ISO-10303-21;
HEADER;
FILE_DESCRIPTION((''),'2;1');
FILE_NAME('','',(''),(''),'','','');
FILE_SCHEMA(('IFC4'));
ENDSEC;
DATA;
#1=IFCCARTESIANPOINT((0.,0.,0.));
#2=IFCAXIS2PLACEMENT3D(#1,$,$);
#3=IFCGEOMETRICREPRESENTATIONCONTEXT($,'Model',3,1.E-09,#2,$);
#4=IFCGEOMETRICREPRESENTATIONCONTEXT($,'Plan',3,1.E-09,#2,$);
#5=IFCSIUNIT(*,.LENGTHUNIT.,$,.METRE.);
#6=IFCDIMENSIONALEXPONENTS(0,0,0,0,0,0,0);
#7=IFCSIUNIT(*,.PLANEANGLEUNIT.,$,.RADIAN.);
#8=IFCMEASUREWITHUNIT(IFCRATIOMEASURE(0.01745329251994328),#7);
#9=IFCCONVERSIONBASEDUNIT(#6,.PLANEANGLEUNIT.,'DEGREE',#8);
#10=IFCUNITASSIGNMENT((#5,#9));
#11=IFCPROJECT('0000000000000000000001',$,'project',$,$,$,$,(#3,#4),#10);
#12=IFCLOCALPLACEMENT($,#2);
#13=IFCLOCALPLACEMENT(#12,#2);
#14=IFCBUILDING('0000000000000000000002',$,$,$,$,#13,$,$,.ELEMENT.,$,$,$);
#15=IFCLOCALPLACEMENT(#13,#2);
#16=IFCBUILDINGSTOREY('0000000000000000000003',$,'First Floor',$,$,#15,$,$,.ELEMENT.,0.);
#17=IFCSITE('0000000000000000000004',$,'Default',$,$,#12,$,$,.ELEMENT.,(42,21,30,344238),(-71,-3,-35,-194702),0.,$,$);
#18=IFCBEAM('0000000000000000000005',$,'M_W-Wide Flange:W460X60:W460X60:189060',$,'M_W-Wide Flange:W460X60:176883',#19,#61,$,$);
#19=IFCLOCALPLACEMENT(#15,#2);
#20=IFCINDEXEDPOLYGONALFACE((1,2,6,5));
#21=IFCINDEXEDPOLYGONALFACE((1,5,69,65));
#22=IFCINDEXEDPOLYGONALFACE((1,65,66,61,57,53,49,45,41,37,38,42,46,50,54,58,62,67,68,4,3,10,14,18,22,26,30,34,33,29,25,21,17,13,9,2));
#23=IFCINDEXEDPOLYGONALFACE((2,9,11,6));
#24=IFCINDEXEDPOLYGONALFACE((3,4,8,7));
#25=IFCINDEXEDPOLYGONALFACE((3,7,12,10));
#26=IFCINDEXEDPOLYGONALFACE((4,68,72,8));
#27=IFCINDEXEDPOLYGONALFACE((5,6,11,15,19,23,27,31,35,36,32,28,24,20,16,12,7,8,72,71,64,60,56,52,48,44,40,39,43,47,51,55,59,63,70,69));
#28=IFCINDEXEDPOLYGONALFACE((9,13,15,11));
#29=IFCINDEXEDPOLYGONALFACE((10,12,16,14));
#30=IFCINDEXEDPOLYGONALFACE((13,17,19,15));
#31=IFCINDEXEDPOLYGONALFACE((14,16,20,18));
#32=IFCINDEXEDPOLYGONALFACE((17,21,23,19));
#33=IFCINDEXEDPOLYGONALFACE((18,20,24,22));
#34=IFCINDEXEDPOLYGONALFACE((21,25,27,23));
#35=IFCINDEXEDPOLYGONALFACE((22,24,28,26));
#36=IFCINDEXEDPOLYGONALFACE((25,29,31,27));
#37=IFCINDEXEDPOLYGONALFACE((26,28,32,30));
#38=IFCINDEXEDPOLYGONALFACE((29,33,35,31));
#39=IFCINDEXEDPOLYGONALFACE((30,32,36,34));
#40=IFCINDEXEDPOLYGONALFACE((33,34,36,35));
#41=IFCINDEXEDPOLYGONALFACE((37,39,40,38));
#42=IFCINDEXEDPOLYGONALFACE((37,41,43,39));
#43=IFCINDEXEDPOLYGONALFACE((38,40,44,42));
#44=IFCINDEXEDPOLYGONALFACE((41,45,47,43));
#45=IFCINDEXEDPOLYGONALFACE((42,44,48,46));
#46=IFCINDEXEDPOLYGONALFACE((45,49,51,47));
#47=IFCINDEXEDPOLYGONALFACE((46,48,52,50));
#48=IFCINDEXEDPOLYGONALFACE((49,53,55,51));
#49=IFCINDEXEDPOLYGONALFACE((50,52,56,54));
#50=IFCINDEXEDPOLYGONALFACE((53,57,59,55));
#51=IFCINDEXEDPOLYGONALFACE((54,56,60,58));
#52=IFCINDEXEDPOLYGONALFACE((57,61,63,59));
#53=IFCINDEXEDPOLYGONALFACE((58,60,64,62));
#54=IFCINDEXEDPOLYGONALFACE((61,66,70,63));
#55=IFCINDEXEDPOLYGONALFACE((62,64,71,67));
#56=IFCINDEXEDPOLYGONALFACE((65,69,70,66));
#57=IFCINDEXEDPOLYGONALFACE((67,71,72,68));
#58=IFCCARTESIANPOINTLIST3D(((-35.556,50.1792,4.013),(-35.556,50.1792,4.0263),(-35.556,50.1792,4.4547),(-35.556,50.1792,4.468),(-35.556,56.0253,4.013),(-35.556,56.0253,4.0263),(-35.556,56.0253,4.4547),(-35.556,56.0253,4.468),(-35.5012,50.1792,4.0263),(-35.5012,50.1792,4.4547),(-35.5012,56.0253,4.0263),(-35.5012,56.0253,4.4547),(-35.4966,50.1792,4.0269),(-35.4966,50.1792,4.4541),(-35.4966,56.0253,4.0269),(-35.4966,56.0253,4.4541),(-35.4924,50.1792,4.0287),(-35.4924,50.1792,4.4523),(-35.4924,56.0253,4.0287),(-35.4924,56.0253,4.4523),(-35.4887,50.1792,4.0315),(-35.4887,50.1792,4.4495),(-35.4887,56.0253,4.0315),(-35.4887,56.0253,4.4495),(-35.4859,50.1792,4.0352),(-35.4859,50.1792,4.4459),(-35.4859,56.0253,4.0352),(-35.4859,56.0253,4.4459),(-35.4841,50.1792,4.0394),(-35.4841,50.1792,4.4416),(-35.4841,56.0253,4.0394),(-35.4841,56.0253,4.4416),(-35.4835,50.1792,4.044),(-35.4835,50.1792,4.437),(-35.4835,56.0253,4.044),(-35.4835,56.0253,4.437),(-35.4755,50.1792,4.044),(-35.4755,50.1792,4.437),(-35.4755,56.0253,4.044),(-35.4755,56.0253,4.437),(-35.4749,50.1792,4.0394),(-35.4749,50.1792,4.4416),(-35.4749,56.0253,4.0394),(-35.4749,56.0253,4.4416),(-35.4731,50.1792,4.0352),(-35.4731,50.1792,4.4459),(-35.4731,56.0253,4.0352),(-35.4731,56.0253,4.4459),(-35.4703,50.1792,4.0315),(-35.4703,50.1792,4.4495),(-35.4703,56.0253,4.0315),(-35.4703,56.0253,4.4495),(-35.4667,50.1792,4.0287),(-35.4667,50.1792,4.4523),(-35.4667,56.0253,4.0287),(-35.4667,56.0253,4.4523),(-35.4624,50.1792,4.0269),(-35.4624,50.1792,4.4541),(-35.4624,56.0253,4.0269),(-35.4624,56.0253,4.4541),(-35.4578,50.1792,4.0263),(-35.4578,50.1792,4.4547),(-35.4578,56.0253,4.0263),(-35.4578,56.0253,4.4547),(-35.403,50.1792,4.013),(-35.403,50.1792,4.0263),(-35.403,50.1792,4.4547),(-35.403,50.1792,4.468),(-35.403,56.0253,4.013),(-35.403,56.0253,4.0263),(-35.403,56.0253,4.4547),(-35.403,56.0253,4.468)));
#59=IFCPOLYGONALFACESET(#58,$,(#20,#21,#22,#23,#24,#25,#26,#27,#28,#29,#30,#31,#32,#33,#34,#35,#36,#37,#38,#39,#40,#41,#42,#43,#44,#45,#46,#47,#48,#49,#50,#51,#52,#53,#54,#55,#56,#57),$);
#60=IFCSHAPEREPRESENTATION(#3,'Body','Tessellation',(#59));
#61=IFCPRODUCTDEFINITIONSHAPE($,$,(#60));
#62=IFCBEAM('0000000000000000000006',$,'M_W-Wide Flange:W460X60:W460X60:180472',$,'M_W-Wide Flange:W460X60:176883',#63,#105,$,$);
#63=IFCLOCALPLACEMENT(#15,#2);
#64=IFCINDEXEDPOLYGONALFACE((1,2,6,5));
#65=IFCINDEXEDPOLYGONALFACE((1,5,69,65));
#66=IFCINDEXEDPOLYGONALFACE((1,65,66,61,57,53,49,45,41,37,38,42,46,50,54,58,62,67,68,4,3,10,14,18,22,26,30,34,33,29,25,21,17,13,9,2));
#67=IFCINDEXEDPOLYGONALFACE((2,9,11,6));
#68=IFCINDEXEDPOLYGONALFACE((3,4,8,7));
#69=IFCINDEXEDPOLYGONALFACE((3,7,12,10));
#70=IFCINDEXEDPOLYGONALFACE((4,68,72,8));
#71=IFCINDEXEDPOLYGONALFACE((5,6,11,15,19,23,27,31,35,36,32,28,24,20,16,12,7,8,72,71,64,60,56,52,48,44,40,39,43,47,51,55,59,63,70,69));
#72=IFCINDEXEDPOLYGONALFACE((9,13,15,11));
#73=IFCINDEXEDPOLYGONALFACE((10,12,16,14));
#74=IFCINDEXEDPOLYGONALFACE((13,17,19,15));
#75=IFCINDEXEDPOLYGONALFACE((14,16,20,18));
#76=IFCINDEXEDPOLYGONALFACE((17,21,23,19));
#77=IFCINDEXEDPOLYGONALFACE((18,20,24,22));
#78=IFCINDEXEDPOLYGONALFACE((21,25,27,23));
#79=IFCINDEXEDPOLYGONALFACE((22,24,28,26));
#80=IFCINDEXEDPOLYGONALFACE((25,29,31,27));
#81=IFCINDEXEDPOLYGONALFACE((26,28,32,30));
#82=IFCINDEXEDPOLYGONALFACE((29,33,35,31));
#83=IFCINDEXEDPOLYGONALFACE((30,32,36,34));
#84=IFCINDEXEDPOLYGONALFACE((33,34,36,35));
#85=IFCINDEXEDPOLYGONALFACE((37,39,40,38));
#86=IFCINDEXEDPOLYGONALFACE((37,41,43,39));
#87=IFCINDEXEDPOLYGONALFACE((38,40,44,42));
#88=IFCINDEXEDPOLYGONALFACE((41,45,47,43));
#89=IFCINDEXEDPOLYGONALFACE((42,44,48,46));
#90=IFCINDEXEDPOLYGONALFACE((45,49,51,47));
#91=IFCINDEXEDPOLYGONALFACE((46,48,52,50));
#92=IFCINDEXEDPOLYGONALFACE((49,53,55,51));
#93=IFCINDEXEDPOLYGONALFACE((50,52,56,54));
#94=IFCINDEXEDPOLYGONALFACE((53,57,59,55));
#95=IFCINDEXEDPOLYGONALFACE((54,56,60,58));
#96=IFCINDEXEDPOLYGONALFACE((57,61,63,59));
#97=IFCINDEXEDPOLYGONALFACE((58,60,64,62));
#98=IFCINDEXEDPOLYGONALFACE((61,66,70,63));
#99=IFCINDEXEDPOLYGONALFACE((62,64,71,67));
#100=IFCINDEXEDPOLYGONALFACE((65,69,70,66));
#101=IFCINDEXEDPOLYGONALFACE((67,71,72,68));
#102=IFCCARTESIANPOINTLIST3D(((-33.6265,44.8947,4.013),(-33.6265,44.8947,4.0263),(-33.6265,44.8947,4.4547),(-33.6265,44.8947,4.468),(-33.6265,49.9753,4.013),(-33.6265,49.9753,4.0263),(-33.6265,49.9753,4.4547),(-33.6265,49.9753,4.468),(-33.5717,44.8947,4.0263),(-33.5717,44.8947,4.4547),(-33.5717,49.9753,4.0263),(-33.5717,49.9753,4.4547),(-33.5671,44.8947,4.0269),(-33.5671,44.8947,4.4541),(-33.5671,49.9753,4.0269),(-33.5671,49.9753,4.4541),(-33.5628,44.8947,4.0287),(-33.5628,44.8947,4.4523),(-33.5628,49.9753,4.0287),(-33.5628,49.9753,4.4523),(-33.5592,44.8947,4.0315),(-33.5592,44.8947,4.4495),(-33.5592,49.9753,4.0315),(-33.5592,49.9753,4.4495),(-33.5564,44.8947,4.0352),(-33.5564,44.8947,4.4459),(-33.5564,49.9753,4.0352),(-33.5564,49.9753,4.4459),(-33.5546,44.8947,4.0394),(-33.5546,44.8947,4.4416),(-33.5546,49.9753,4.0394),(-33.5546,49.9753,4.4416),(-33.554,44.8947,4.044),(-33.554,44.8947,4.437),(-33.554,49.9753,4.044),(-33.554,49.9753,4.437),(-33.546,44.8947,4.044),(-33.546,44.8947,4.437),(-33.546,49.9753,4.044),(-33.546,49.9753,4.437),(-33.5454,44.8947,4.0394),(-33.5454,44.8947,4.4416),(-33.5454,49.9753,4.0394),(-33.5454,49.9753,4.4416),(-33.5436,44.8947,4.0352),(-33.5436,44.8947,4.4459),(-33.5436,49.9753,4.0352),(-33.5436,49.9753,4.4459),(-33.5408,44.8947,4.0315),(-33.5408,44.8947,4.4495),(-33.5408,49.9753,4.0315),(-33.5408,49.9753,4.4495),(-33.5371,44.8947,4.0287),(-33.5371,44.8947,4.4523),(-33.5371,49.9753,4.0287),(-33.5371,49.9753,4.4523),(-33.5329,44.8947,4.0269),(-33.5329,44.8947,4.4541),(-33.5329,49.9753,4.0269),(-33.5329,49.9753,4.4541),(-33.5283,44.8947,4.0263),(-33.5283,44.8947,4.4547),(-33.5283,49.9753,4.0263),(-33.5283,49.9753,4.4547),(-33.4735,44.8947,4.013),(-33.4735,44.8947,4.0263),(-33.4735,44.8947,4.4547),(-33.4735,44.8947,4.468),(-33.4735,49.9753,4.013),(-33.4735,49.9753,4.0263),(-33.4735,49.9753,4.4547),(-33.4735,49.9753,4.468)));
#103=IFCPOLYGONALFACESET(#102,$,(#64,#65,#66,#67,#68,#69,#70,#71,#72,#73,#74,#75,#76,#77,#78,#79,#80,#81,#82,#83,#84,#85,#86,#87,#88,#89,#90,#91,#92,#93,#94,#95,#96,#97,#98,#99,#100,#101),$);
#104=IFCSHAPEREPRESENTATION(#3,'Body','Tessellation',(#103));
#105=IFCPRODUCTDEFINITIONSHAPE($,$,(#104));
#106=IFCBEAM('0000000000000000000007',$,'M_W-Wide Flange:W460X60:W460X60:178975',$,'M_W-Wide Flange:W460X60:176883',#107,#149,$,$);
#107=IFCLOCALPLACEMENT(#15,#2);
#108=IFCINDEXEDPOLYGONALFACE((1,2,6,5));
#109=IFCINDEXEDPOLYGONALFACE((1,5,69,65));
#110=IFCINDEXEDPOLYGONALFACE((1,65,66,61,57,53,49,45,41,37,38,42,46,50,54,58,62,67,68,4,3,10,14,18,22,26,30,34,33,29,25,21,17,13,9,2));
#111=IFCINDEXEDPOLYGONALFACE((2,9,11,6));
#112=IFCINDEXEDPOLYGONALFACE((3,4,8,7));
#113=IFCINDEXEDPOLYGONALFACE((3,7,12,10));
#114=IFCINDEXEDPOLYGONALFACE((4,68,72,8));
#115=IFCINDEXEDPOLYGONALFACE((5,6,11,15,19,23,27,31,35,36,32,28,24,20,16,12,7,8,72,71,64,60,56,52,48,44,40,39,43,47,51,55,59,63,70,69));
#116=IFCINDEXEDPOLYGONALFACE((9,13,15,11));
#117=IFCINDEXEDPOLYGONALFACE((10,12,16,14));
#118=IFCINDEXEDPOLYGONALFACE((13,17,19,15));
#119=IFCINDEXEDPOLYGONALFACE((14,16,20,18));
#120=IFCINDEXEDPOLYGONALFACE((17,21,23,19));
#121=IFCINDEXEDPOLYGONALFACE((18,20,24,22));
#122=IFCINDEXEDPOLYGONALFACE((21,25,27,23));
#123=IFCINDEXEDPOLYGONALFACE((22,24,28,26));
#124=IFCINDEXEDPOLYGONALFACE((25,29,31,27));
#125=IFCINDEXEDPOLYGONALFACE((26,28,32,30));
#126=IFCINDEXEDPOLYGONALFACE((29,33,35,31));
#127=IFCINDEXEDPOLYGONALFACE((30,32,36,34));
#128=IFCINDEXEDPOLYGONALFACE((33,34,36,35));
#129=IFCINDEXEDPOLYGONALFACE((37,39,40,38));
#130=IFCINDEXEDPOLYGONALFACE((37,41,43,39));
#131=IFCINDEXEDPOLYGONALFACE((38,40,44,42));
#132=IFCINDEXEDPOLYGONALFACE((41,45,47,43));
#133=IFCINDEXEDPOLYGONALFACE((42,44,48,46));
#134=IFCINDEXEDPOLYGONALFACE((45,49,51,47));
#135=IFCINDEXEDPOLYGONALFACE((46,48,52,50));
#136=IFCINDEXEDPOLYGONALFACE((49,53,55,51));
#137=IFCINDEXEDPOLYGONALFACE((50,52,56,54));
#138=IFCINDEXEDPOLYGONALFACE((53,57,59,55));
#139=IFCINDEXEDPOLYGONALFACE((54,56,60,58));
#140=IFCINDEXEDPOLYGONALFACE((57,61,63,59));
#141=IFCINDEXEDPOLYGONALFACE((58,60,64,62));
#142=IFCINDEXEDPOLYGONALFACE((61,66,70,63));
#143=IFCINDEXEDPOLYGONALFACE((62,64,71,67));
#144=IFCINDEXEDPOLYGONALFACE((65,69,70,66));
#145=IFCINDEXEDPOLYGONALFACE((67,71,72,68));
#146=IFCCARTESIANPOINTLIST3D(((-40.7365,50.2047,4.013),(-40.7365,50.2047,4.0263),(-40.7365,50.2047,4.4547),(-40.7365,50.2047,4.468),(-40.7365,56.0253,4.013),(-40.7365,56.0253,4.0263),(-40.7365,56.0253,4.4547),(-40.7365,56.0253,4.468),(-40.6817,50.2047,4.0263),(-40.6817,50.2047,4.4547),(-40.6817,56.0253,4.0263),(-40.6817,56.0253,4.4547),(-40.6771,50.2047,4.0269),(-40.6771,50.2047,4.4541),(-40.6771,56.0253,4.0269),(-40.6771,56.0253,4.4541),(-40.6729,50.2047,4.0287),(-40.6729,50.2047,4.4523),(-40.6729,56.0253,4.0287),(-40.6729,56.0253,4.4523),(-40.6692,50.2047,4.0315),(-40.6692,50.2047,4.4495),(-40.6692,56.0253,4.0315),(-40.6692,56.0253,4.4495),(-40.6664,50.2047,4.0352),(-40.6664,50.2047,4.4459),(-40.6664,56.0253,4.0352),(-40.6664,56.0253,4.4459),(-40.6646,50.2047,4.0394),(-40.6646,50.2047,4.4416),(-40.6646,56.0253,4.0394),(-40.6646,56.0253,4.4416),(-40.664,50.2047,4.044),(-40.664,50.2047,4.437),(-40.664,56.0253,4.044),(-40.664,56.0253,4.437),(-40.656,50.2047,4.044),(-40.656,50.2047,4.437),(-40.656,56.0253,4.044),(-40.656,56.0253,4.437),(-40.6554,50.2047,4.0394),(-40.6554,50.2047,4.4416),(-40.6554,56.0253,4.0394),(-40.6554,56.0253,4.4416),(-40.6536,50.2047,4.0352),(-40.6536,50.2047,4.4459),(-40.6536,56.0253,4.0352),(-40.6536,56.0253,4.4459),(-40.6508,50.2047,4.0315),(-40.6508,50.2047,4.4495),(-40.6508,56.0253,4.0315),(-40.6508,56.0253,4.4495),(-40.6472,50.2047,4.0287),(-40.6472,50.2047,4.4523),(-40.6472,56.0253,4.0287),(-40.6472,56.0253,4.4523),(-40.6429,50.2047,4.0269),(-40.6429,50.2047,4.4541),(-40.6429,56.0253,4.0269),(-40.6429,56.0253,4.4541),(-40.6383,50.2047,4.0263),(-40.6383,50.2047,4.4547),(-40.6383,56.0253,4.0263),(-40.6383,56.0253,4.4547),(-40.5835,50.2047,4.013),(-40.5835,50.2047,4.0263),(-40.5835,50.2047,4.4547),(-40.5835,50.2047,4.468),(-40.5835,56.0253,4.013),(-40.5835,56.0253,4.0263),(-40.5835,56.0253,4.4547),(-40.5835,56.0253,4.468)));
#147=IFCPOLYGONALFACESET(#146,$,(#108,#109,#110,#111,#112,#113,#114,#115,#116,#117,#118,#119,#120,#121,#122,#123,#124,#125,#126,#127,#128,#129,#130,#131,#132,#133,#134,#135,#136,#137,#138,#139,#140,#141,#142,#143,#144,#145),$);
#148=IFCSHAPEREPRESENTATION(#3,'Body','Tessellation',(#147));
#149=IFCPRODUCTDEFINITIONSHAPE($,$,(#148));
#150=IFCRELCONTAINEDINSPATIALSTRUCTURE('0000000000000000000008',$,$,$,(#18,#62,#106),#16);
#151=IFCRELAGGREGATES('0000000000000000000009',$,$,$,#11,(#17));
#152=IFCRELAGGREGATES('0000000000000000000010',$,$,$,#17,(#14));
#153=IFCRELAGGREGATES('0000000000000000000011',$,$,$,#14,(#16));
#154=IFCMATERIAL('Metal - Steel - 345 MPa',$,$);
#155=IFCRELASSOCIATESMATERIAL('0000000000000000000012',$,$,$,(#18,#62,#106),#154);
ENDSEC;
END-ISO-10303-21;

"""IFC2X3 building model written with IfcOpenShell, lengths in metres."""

from ifc_helpers import new_model, entity, si_unit, converted_unit, frame, frame_2d, origin, place, context, project, spatial, polyline, circle_curve, parameter, trimmed, segment, composite_curve, outline, extrude, material, element, save


model = new_model("IFC2X3")

# Units and contexts
model_context = context("Model", 3, precision=1e-09, world=origin())
plan_context = context("Plan", 3, precision=1e-09, world=origin())
ifc_project = project(units=[si_unit("LENGTHUNIT", "METRE"), converted_unit("PLANEANGLEUNIT", "DEGREE", entity("IfcRatioMeasure", 0.01745329251994328), si_unit("PLANEANGLEUNIT", "RADIAN"), dimensions=[0, 0, 0, 0, 0, 0, 0])], contexts=[model_context, plan_context])

# Site, building, storey
site_placement = place(None, origin())
site = spatial("IfcSite", under=ifc_project, at=site_placement, Name="Default", CompositionType="ELEMENT", RefLatitude=(42, 21, 30, 344238), RefLongitude=(-71, -3, -35, -194702), RefElevation=0.0)
building_placement = place(site_placement, origin())
building = spatial("IfcBuilding", under=site, at=building_placement, CompositionType="ELEMENT")
storey_placement = place(building_placement, origin())
storey = spatial("IfcBuildingStorey", under=building, at=storey_placement, Name="First Floor", CompositionType="ELEMENT", Elevation=0.0)

# Beams
ifc_material = material(Name="Metal - Steel - 345 MPa")
beam_1_placement = place(storey_placement, frame((-35.4795, 50.2447, 4.468)))
element("IfcBeam", 1, at=beam_1_placement, inside=storey, material=ifc_material, Name="M_W-Wide Flange:W460X60:W460X60:189060", ObjectType="M_W-Wide Flange:W460X60:176883", context=model_context, shape_type="SweptSolid", body=[
    extrude(outline(composite_curve([segment(polyline([(-0.0765, -0.2142), (-0.0765, -0.2275)]), True, "CONTINUOUS"), segment(polyline([(-0.0765, -0.2275), (0.0765, -0.2275)]), True, "CONTINUOUS"), segment(polyline([(0.0765, -0.2275), (0.0765, -0.2142)]), True, "CONTINUOUS"), segment(polyline([(0.0765, -0.2142), (0.0217, -0.2142)]), True, "CONTINUOUS"), segment(trimmed(circle_curve(frame_2d((0.0217, -0.1965), x_axis=(1.0, 0.0)), 0.0177), [parameter(180.0)], [parameter(270.0)], True, "PARAMETER"), False, "CONTINUOUS"), segment(polyline([(0.004, -0.1965), (0.004, 0.1965)]), True, "CONTINUOUS"), segment(trimmed(circle_curve(frame_2d((0.0217, 0.1965), x_axis=(1.0, 0.0)), 0.0177), [parameter(90.0)], [parameter(180.0)], True, "PARAMETER"), False, "CONTINUOUS"), segment(polyline([(0.0217, 0.2142), (0.0765, 0.2142)]), True, "CONTINUOUS"), segment(polyline([(0.0765, 0.2142), (0.0765, 0.2275)]), True, "CONTINUOUS"), segment(polyline([(0.0765, 0.2275), (-0.0765, 0.2275)]), True, "CONTINUOUS"), segment(polyline([(-0.0765, 0.2275), (-0.0765, 0.2142)]), True, "CONTINUOUS"), segment(polyline([(-0.0765, 0.2142), (-0.0217, 0.2142)]), True, "CONTINUOUS"), segment(trimmed(circle_curve(frame_2d((-0.0217, 0.1965), x_axis=(1.0, 0.0)), 0.0177), [parameter(360.0)], [parameter(90.0)], True, "PARAMETER"), False, "CONTINUOUS"), segment(polyline([(-0.004, 0.1965), (-0.004, -0.1965)]), True, "CONTINUOUS"), segment(trimmed(circle_curve(frame_2d((-0.0217, -0.1965), x_axis=(1.0, 0.0)), 0.0177), [parameter(270.0)], [parameter(0.0)], True, "PARAMETER"), False, "CONTINUOUS"), segment(polyline([(-0.0217, -0.2142), (-0.0765, -0.2142)]), True, "CONTINUOUS")], self_intersect=False)), frame((0.0, -0.0655, -0.2275), z_axis=(0.0, -1.0, 0.0), x_axis=(1.0, 0.0, 0.0)), (0.0, 0.0, -1.0), 5.8461),
])
beam_2_placement = place(storey_placement, frame((-33.55, 50.0926, 4.468), z_axis=(0.0, 0.0, 1.0), x_axis=(-1.0, 0.0, 0.0)))
element("IfcBeam", 2, at=beam_2_placement, inside=storey, material=ifc_material, Name="M_W-Wide Flange:W460X60:W460X60:180472", ObjectType="M_W-Wide Flange:W460X60:176883", context=model_context, shape_type="SweptSolid", body=[
    extrude(outline(composite_curve([segment(polyline([(0.2142, -0.0765), (0.2275, -0.0765)]), True, "CONTINUOUS"), segment(polyline([(0.2275, -0.0765), (0.2275, 0.0765)]), True, "CONTINUOUS"), segment(polyline([(0.2275, 0.0765), (0.2142, 0.0765)]), True, "CONTINUOUS"), segment(polyline([(0.2142, 0.0765), (0.2142, 0.0217)]), True, "CONTINUOUS"), segment(trimmed(circle_curve(frame_2d((0.1965, 0.0217), x_axis=(1.0, 0.0)), 0.0177), [parameter(270.0)], [parameter(360.0)], True, "PARAMETER"), False, "CONTINUOUS"), segment(polyline([(0.1965, 0.004), (-0.1965, 0.004)]), True, "CONTINUOUS"), segment(trimmed(circle_curve(frame_2d((-0.1965, 0.0217), x_axis=(0.0, -1.0)), 0.0177), [parameter(270.0)], [parameter(360.0)], True, "PARAMETER"), False, "CONTINUOUS"), segment(polyline([(-0.2142, 0.0217), (-0.2142, 0.0765)]), True, "CONTINUOUS"), segment(polyline([(-0.2142, 0.0765), (-0.2275, 0.0765)]), True, "CONTINUOUS"), segment(polyline([(-0.2275, 0.0765), (-0.2275, -0.0765)]), True, "CONTINUOUS"), segment(polyline([(-0.2275, -0.0765), (-0.2142, -0.0765)]), True, "CONTINUOUS"), segment(polyline([(-0.2142, -0.0765), (-0.2142, -0.0217)]), True, "CONTINUOUS"), segment(trimmed(circle_curve(frame_2d((-0.1965, -0.0217), x_axis=(-1.0, 0.0)), 0.0177), [parameter(270.0)], [parameter(360.0)], True, "PARAMETER"), False, "CONTINUOUS"), segment(polyline([(-0.1965, -0.004), (0.1965, -0.004)]), True, "CONTINUOUS"), segment(trimmed(circle_curve(frame_2d((0.1965, -0.0217), x_axis=(0.0, 1.0)), 0.0177), [parameter(270.0)], [parameter(0.0)], True, "PARAMETER"), False, "CONTINUOUS"), segment(polyline([(0.2142, -0.0217), (0.2142, -0.0765)]), True, "CONTINUOUS")], self_intersect=False)), frame((0.0, 5.1979, -0.2275), z_axis=(0.0, -1.0, 0.0), x_axis=(0.0, 0.0, -1.0)), (0.0, 0.0, 1.0), 5.0806),
])
beam_3_placement = place(storey_placement, frame((-40.66, 56.1423, 4.468), z_axis=(0.0, 0.0, 1.0), x_axis=(-1.0, 0.0, 0.0)))
element("IfcBeam", 3, at=beam_3_placement, inside=storey, material=ifc_material, Name="M_W-Wide Flange:W460X60:W460X60:178975", ObjectType="M_W-Wide Flange:W460X60:176883", context=model_context, shape_type="SweptSolid", body=[
    extrude(outline(composite_curve([segment(polyline([(0.2142, -0.0765), (0.2275, -0.0765)]), True, "CONTINUOUS"), segment(polyline([(0.2275, -0.0765), (0.2275, 0.0765)]), True, "CONTINUOUS"), segment(polyline([(0.2275, 0.0765), (0.2142, 0.0765)]), True, "CONTINUOUS"), segment(polyline([(0.2142, 0.0765), (0.2142, 0.0217)]), True, "CONTINUOUS"), segment(trimmed(circle_curve(frame_2d((0.1965, 0.0217), x_axis=(0.0, 1.0)), 0.0177), [parameter(180.0)], [parameter(270.0)], True, "PARAMETER"), False, "CONTINUOUS"), segment(polyline([(0.1965, 0.004), (-0.1965, 0.004)]), True, "CONTINUOUS"), segment(trimmed(circle_curve(frame_2d((-0.1965, 0.0217), x_axis=(0.0, 1.0)), 0.0177), [parameter(90.0)], [parameter(180.0)], True, "PARAMETER"), False, "CONTINUOUS"), segment(polyline([(-0.2142, 0.0217), (-0.2142, 0.0765)]), True, "CONTINUOUS"), segment(polyline([(-0.2142, 0.0765), (-0.2275, 0.0765)]), True, "CONTINUOUS"), segment(polyline([(-0.2275, 0.0765), (-0.2275, -0.0765)]), True, "CONTINUOUS"), segment(polyline([(-0.2275, -0.0765), (-0.2142, -0.0765)]), True, "CONTINUOUS"), segment(polyline([(-0.2142, -0.0765), (-0.2142, -0.0217)]), True, "CONTINUOUS"), segment(trimmed(circle_curve(frame_2d((-0.1965, -0.0217), x_axis=(0.0, 1.0)), 0.0177), [parameter(360.0)], [parameter(90.0)], True, "PARAMETER"), False, "CONTINUOUS"), segment(polyline([(-0.1965, -0.004), (0.1965, -0.004)]), True, "CONTINUOUS"), segment(trimmed(circle_curve(frame_2d((0.1965, -0.0217), x_axis=(0.0, 1.0)), 0.0177), [parameter(270.0)], [parameter(0.0)], True, "PARAMETER"), False, "CONTINUOUS"), segment(polyline([(0.2142, -0.0217), (0.2142, -0.0765)]), True, "CONTINUOUS")], self_intersect=False)), frame((0.0, 5.9376, -0.2275), z_axis=(0.0, -1.0, 0.0), x_axis=(0.0, 0.0, -1.0)), (0.0, 0.0, 1.0), 5.8206),
])

save(model, "model.ifc")
